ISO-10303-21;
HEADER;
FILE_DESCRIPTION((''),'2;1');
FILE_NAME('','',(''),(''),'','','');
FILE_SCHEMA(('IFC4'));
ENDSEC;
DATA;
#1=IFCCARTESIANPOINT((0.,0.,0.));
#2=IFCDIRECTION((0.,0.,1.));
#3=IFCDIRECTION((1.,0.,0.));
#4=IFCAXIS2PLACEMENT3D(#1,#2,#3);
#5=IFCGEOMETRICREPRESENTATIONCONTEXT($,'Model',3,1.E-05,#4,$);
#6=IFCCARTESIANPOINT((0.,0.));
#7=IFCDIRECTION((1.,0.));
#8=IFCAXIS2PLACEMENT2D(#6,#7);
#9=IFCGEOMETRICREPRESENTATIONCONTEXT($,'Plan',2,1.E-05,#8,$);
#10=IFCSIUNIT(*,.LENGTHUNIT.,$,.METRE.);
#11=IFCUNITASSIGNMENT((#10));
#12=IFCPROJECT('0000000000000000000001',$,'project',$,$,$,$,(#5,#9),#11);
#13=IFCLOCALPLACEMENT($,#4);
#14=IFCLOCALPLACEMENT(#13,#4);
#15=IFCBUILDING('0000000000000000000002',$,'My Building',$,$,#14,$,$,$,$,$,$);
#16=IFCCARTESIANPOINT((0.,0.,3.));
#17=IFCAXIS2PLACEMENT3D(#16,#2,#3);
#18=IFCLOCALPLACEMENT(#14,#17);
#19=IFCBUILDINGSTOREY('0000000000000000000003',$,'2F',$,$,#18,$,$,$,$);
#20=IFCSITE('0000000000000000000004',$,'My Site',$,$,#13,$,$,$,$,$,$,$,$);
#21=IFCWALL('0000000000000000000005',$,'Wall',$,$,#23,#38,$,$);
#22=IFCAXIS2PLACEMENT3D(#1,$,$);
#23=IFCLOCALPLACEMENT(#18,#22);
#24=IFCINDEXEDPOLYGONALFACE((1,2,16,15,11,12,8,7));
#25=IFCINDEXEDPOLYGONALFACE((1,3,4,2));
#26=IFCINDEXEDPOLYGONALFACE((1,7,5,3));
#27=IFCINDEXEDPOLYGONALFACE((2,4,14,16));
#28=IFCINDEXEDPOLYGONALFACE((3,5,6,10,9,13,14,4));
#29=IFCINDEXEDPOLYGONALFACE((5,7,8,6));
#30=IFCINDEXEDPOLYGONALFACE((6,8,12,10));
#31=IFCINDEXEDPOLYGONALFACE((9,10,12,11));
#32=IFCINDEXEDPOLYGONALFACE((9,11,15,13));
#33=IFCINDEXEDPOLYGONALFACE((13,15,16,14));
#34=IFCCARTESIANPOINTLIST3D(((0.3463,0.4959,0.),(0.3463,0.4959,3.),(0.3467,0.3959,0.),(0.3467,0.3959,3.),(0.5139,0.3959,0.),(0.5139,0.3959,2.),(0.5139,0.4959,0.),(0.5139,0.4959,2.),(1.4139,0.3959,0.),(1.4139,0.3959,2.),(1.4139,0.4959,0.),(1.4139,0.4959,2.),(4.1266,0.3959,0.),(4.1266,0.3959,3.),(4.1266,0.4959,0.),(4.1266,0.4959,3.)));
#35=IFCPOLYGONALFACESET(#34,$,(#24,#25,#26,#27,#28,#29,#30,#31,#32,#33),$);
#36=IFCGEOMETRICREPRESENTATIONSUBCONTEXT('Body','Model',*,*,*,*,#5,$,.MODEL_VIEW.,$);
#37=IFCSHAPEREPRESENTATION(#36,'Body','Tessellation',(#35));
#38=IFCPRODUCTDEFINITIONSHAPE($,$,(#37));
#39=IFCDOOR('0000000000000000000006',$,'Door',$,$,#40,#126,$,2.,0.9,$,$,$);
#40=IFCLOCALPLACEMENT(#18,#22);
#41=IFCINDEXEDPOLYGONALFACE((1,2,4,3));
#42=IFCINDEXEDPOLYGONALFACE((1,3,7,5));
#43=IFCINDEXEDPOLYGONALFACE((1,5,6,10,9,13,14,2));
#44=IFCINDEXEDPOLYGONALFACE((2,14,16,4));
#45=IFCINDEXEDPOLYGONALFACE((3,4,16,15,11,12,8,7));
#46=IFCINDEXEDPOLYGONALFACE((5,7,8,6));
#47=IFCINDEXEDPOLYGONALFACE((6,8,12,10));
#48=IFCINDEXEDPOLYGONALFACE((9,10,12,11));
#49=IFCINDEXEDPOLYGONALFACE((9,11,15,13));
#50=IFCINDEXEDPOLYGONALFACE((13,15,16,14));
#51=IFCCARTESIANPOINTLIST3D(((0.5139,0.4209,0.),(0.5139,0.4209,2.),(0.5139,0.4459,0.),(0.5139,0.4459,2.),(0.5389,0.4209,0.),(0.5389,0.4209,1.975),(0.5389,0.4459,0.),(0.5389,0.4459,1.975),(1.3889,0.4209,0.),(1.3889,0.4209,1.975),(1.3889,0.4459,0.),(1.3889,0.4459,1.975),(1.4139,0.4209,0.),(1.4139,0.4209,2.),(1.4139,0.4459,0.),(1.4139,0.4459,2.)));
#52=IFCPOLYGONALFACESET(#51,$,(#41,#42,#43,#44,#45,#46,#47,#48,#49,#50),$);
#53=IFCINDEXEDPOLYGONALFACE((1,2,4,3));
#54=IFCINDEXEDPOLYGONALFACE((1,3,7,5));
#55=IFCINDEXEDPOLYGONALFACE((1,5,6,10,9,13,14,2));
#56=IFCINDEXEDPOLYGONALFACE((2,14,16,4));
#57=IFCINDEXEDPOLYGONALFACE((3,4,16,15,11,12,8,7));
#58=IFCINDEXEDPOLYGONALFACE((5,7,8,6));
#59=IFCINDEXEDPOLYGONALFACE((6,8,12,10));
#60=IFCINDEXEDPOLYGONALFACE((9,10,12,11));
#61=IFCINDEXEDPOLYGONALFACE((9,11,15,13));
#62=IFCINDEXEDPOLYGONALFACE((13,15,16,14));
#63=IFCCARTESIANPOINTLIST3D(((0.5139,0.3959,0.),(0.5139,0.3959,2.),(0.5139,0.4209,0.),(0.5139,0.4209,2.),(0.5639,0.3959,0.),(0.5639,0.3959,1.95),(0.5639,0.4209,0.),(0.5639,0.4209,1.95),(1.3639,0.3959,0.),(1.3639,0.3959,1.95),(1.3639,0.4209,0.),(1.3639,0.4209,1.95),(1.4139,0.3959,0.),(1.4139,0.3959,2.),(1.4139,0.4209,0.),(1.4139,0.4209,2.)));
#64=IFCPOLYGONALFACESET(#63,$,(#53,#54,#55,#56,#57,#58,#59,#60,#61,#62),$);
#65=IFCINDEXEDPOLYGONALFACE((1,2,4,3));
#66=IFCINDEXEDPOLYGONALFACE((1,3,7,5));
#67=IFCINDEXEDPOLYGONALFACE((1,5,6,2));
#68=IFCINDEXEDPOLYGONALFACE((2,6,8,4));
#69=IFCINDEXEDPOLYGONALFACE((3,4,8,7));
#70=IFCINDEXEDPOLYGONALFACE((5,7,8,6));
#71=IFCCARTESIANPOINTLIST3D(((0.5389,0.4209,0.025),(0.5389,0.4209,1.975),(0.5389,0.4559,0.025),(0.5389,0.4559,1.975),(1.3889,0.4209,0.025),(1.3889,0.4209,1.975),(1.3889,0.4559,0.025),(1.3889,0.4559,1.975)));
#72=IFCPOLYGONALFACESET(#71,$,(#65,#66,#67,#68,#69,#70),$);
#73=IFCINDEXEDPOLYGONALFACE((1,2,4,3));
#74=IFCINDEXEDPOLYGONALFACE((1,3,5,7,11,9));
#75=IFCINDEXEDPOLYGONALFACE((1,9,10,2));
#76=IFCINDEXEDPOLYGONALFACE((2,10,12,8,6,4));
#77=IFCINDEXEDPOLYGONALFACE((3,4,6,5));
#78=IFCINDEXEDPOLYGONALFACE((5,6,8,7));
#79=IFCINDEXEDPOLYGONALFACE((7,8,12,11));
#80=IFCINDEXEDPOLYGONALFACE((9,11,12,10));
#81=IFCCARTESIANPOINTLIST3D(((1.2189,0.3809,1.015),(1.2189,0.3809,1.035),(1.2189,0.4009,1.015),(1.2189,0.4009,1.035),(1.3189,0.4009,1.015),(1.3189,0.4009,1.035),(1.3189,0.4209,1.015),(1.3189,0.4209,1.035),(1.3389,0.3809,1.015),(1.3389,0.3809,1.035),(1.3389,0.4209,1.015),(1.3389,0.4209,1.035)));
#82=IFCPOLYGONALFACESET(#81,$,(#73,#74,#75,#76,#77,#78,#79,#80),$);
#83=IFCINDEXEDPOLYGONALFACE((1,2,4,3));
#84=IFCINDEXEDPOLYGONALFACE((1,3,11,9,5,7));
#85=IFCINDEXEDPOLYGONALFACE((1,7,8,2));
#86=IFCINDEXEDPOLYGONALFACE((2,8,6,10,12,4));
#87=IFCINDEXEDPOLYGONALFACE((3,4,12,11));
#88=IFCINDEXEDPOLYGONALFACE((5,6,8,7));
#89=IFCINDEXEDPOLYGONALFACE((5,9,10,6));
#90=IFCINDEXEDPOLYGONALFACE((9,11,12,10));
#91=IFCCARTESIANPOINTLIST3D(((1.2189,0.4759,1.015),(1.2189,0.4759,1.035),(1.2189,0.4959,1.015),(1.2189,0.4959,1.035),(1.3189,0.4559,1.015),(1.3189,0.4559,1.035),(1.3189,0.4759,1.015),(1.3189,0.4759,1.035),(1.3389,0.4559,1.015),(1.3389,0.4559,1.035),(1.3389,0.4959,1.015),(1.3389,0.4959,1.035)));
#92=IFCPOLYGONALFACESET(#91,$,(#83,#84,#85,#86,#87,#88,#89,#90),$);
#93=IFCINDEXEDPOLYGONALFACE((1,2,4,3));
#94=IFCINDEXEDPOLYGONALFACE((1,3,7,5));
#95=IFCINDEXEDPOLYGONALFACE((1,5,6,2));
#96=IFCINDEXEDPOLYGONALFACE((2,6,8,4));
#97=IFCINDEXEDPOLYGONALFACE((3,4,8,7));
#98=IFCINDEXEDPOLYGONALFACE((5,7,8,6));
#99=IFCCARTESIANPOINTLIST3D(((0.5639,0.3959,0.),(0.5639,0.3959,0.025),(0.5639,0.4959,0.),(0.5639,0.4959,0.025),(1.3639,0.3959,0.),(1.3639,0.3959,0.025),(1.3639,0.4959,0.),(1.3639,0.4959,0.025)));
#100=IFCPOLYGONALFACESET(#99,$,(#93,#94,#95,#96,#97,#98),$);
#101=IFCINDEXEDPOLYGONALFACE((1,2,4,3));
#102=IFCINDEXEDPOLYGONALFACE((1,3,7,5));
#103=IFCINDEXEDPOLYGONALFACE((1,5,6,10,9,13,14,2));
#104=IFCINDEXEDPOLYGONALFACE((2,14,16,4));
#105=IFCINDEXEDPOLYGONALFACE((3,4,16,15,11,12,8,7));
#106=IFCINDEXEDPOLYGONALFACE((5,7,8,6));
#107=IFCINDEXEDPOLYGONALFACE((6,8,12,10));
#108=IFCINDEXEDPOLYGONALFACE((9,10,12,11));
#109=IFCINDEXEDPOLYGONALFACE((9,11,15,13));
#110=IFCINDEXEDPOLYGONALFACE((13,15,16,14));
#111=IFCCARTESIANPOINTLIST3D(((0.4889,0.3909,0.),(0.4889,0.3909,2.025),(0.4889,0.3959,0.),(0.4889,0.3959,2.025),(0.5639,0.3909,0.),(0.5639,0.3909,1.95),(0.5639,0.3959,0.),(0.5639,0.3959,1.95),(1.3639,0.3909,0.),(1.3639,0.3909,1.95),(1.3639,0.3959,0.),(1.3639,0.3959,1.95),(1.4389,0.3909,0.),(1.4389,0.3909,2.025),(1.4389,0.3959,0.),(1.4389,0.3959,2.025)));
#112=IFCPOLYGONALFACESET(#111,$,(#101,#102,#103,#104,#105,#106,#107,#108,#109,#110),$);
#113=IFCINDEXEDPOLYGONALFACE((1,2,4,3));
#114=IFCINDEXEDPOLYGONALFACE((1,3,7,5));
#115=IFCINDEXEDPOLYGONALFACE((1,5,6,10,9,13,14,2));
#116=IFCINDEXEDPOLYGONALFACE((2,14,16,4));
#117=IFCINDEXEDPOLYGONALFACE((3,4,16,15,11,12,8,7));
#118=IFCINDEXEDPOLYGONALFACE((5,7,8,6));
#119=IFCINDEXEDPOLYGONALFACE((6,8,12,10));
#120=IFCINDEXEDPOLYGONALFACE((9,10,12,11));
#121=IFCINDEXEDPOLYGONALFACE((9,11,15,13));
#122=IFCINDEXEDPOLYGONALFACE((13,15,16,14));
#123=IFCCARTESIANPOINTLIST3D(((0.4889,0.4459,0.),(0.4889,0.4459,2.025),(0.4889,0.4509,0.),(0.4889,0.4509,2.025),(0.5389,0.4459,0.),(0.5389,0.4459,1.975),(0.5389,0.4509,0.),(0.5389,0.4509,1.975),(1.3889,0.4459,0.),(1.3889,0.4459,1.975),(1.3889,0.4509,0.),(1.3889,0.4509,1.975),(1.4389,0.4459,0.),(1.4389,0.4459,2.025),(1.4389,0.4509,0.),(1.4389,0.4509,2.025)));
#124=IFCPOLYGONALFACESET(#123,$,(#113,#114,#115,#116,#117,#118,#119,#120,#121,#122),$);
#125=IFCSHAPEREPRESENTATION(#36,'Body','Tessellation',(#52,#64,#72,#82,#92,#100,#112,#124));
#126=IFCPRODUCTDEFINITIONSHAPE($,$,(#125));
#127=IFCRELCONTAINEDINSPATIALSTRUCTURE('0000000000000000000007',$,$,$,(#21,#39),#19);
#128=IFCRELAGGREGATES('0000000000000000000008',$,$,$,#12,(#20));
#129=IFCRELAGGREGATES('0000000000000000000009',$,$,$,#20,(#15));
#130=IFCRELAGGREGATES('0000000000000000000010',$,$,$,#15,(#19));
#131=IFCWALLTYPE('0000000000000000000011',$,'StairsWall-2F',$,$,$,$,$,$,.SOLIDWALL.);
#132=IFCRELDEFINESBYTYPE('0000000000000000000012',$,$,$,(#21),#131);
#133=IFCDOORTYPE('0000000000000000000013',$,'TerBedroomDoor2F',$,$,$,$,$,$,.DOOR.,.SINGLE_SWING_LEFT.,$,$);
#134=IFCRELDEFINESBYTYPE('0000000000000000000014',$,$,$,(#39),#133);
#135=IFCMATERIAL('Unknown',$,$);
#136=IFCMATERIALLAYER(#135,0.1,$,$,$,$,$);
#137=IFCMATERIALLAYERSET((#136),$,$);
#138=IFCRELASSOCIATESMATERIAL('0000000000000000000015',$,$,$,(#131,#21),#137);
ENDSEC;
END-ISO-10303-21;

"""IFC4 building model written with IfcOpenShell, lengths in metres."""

from ifc_helpers import new_model, entity, si_unit, frame, origin_with_axes, origin_2d_with_axis, place, context, subcontext, project, spatial, line, indexed_curve, outline, extrude, shape, source, transform, mapped, material, layer, layer_set, layer_usage, type_object, type_shapes, element, fill, save


model = new_model("IFC4")

# Units and contexts
model_context = context("Model", 3, precision=1e-05, world=origin_with_axes())
plan_context = context("Plan", 2, precision=1e-05, world=origin_2d_with_axis())
body_context_1 = subcontext(model_context, "Body", "Model", "MODEL_VIEW")
body_context_2 = subcontext(plan_context, "Body", "Plan", "PLAN_VIEW")
ifc_project = project(units=[si_unit("LENGTHUNIT", "METRE")], contexts=[model_context, plan_context])

# Site, building, storey
site_placement = place(None, origin_with_axes())
site = spatial("IfcSite", under=ifc_project, at=site_placement, Name="My Site")
building_placement = place(site_placement, origin_with_axes())
building = spatial("IfcBuilding", under=site, at=building_placement, Name="My Building")
storey_placement = place(building_placement, frame((0.0, 0.0, 3.0), z_axis=(0.0, 0.0, 1.0), x_axis=(1.0, 0.0, 0.0)))
storey = spatial("IfcBuildingStorey", under=building, at=storey_placement, Name="2F")

# Shared definitions
ifc_material = material(Name="Unknown")

# Wall, opening, door
ifc_layer_1 = layer(ifc_material, 0.1)
ifc_layer_set_1 = layer_set([ifc_layer_1])
ifc_layer_usage_1 = layer_usage(ifc_layer_set_1, "AXIS2", "POSITIVE", 0.0)
wall_type_1 = type_object("IfcWallType", Name="StairsWall-2F", PredefinedType="SOLIDWALL", material=ifc_layer_set_1)
wall_1_placement = place(storey_placement, frame((4.2266, 0.4959, 0.0), z_axis=(0.0, 0.0, 1.0), x_axis=(-1.0, 0.0, 0.0)))
wall_1 = element("IfcWall", 1, at=wall_1_placement, inside=storey, type_object=wall_type_1, material=ifc_layer_usage_1, Name="Wall", context=body_context_1, shape_type="SweptSolid", body=[
    extrude(outline(indexed_curve([(0.1, 0.0), (0.1, 0.1), (3.8799, 0.1), (3.8803, 0.0)], segments=[line(1, 2, 3, 4, 1)])), origin_with_axes(), (0.0, 0.0, 1.0), 3.0),
])
shared_shape_1 = source(origin_with_axes(), body_context_1, "Body", "SweptSolid", [
    extrude(outline(indexed_curve([(0.0, 0.0), (0.9, 0.0), (0.9, 2.0), (0.0, 2.0)], segments=[line(1, 2, 3, 4, 1)])), frame((0.0, -0.6, 0.0), z_axis=(0.0, -1.0, 0.0), x_axis=(1.0, 0.0, 0.0)), (0.0, 0.0, -1.0), 1.2),
])
opening_1_placement = place(wall_1_placement, frame((3.7127, 0.1, 0.0), z_axis=(0.0, 0.0, 1.0), x_axis=(-1.0, 0.0, 0.0)))
opening_1 = element("IfcOpeningElement", 2, at=opening_1_placement, cuts=wall_1, PredefinedType="OPENING", context=body_context_1, shape_type="MappedRepresentation", body=[
    mapped(shared_shape_1, transform((0.0, 0.0, 0.0), x_axis=(1.0, 0.0, 0.0), y_axis=(0.0, 1.0, 0.0), z_axis=(0.0, 0.0, 1.0), scale=1.0)),
])
door_type_1 = type_object("IfcDoorType", Name="TerBedroomDoor2F", OperationType="SINGLE_SWING_LEFT", PredefinedType="DOOR")
shared_shape_2 = source(origin_with_axes(), body_context_1, "Body", "SweptSolid", [
    extrude(outline(indexed_curve([(0.0, 0.0), (0.0, 2.0), (0.9, 2.0), (0.9, 0.0), (0.875, 0.0), (0.875, 1.975), (0.025, 1.975), (0.025, 0.0)], segments=[line(1, 2, 3, 4, 5, 6, 7, 8, 1)])), frame((0.0, 0.025, 0.0), z_axis=(0.0, -1.0, 0.0), x_axis=(1.0, 0.0, 0.0)), (0.0, 0.0, -1.0), 0.025),
    extrude(outline(indexed_curve([(0.0, 0.0), (0.0, 2.0), (0.9, 2.0), (0.9, 0.0), (0.85, 0.0), (0.85, 1.95), (0.05, 1.95), (0.05, 0.0)], segments=[line(1, 2, 3, 4, 5, 6, 7, 8, 1)])), frame((0.0, 0.0, 0.0), z_axis=(0.0, -1.0, 0.0), x_axis=(1.0, 0.0, 0.0)), (0.0, 0.0, -1.0), 0.025),
    extrude(outline(indexed_curve([(0.0, 0.0), (0.85, 0.0), (0.85, 0.035), (0.0, 0.035)], segments=[line(1, 2, 3, 4, 1)])), frame((0.025, 0.025, 0.025), z_axis=(0.0, 0.0, 1.0), x_axis=(1.0, 0.0, 0.0)), (0.0, 0.0, 1.0), 1.95),
    extrude(outline(indexed_curve([(0.0, 0.0), (0.0, -0.04), (-0.12, -0.04), (-0.12, -0.02), (-0.02, -0.02), (-0.02, 0.0)], segments=[line(1, 2, 3, 4, 5, 6, 1)])), frame((0.825, 0.025, 1.015), z_axis=(0.0, 0.0, 1.0), x_axis=(1.0, 0.0, 0.0)), (0.0, 0.0, 1.0), 0.02),
    extrude(outline(indexed_curve([(0.0, 0.0), (0.0, 0.04), (-0.12, 0.04), (-0.12, 0.02), (-0.02, 0.02), (-0.02, 0.0)], segments=[line(1, 2, 3, 4, 5, 6, 1)])), frame((0.825, 0.06, 1.015), z_axis=(0.0, 0.0, 1.0), x_axis=(1.0, 0.0, 0.0)), (0.0, 0.0, 1.0), 0.02),
    extrude(outline(indexed_curve([(0.0, 0.0), (0.8, 0.0), (0.8, 0.1), (0.0, 0.1)], segments=[line(1, 2, 3, 4, 1)])), frame((0.05, 0.0, 0.0), z_axis=(0.0, 0.0, 1.0), x_axis=(1.0, 0.0, 0.0)), (0.0, 0.0, 1.0), 0.025),
    extrude(outline(indexed_curve([(0.0, 0.0), (0.0, 2.025), (0.95, 2.025), (0.95, 0.0), (0.875, 0.0), (0.875, 1.95), (0.075, 1.95), (0.075, 0.0)], segments=[line(1, 2, 3, 4, 5, 6, 7, 8, 1)])), frame((-0.025, -0.005, 0.0), z_axis=(0.0, -1.0, 0.0), x_axis=(1.0, 0.0, 0.0)), (0.0, 0.0, -1.0), 0.005),
    extrude(outline(indexed_curve([(0.0, 0.0), (0.0, 2.025), (0.95, 2.025), (0.95, 0.0), (0.9, 0.0), (0.9, 1.975), (0.05, 1.975), (0.05, 0.0)], segments=[line(1, 2, 3, 4, 5, 6, 7, 8, 1)])), frame((-0.025, 0.05, 0.0), z_axis=(0.0, -1.0, 0.0), x_axis=(1.0, 0.0, 0.0)), (0.0, 0.0, -1.0), 0.005),
])
shared_shape_3 = source(origin_with_axes(), body_context_2, "Body", "Curve2D", [
    entity("IfcIndexedPolyCurve", entity("IfcCartesianPointList2D", [[0.0, 0.0], [0.0, 0.05], [0.025, 0.05], [0.025, 0.025], [0.05, 0.025], [0.05, 0.0]]), [entity("IfcLineIndex", [1, 2, 3, 4, 5, 6, 1])]),
    entity("IfcIndexedPolyCurve", entity("IfcCartesianPointList2D", [[0.9, 0.0], [0.9, 0.05], [0.875, 0.05], [0.875, 0.025], [0.85, 0.025], [0.85, 0.0]]), [entity("IfcLineIndex", [1, 2, 3, 4, 5, 6, 1])]),
    entity("IfcTrimmedCurve", entity("IfcEllipse", entity("IfcAxis2Placement2D", entity("IfcCartesianPoint", [0.06, 0.05]), entity("IfcDirection", [1.0, 0.0])), 0.815, 0.85), [entity("IfcCartesianPoint", [0.875, 0.05])], [entity("IfcCartesianPoint", [0.06, 0.9])], True, "CARTESIAN"),
    entity("IfcIndexedPolyCurve", entity("IfcCartesianPointList2D", [[0.025, 0.05], [0.06, 0.05], [0.06, 0.9], [0.025, 0.9]]), [entity("IfcLineIndex", [1, 2, 3, 4, 1])]),
])
type_shapes(door_type_1, [shared_shape_2, shared_shape_3])
door_1_placement = place(opening_1_placement, frame((0.0, 0.0, 0.0), z_axis=(0.0, 0.0, 1.0), x_axis=(1.0, 0.0, 0.0)))
door_1 = element("IfcDoor", 3, at=door_1_placement, inside=storey, type_object=door_type_1, Name="Door", OverallHeight=2.0, OverallWidth=0.9, shapes=[
    shape(body_context_1, "Body", "MappedRepresentation", [mapped(shared_shape_2, transform((0.0, 0.0, 0.0), x_axis=(1.0, 0.0, 0.0), y_axis=(0.0, 1.0, 0.0), z_axis=(0.0, 0.0, 1.0), scale=1.0))]),
    shape(body_context_2, "Body", "MappedRepresentation", [mapped(shared_shape_3, transform((0.0, 0.0, 0.0), x_axis=(1.0, 0.0, 0.0), y_axis=(0.0, 1.0, 0.0), z_axis=(0.0, 0.0, 1.0), scale=1.0))]),
])
fill(opening_1, door_1)

save(model, "model.ifc")
